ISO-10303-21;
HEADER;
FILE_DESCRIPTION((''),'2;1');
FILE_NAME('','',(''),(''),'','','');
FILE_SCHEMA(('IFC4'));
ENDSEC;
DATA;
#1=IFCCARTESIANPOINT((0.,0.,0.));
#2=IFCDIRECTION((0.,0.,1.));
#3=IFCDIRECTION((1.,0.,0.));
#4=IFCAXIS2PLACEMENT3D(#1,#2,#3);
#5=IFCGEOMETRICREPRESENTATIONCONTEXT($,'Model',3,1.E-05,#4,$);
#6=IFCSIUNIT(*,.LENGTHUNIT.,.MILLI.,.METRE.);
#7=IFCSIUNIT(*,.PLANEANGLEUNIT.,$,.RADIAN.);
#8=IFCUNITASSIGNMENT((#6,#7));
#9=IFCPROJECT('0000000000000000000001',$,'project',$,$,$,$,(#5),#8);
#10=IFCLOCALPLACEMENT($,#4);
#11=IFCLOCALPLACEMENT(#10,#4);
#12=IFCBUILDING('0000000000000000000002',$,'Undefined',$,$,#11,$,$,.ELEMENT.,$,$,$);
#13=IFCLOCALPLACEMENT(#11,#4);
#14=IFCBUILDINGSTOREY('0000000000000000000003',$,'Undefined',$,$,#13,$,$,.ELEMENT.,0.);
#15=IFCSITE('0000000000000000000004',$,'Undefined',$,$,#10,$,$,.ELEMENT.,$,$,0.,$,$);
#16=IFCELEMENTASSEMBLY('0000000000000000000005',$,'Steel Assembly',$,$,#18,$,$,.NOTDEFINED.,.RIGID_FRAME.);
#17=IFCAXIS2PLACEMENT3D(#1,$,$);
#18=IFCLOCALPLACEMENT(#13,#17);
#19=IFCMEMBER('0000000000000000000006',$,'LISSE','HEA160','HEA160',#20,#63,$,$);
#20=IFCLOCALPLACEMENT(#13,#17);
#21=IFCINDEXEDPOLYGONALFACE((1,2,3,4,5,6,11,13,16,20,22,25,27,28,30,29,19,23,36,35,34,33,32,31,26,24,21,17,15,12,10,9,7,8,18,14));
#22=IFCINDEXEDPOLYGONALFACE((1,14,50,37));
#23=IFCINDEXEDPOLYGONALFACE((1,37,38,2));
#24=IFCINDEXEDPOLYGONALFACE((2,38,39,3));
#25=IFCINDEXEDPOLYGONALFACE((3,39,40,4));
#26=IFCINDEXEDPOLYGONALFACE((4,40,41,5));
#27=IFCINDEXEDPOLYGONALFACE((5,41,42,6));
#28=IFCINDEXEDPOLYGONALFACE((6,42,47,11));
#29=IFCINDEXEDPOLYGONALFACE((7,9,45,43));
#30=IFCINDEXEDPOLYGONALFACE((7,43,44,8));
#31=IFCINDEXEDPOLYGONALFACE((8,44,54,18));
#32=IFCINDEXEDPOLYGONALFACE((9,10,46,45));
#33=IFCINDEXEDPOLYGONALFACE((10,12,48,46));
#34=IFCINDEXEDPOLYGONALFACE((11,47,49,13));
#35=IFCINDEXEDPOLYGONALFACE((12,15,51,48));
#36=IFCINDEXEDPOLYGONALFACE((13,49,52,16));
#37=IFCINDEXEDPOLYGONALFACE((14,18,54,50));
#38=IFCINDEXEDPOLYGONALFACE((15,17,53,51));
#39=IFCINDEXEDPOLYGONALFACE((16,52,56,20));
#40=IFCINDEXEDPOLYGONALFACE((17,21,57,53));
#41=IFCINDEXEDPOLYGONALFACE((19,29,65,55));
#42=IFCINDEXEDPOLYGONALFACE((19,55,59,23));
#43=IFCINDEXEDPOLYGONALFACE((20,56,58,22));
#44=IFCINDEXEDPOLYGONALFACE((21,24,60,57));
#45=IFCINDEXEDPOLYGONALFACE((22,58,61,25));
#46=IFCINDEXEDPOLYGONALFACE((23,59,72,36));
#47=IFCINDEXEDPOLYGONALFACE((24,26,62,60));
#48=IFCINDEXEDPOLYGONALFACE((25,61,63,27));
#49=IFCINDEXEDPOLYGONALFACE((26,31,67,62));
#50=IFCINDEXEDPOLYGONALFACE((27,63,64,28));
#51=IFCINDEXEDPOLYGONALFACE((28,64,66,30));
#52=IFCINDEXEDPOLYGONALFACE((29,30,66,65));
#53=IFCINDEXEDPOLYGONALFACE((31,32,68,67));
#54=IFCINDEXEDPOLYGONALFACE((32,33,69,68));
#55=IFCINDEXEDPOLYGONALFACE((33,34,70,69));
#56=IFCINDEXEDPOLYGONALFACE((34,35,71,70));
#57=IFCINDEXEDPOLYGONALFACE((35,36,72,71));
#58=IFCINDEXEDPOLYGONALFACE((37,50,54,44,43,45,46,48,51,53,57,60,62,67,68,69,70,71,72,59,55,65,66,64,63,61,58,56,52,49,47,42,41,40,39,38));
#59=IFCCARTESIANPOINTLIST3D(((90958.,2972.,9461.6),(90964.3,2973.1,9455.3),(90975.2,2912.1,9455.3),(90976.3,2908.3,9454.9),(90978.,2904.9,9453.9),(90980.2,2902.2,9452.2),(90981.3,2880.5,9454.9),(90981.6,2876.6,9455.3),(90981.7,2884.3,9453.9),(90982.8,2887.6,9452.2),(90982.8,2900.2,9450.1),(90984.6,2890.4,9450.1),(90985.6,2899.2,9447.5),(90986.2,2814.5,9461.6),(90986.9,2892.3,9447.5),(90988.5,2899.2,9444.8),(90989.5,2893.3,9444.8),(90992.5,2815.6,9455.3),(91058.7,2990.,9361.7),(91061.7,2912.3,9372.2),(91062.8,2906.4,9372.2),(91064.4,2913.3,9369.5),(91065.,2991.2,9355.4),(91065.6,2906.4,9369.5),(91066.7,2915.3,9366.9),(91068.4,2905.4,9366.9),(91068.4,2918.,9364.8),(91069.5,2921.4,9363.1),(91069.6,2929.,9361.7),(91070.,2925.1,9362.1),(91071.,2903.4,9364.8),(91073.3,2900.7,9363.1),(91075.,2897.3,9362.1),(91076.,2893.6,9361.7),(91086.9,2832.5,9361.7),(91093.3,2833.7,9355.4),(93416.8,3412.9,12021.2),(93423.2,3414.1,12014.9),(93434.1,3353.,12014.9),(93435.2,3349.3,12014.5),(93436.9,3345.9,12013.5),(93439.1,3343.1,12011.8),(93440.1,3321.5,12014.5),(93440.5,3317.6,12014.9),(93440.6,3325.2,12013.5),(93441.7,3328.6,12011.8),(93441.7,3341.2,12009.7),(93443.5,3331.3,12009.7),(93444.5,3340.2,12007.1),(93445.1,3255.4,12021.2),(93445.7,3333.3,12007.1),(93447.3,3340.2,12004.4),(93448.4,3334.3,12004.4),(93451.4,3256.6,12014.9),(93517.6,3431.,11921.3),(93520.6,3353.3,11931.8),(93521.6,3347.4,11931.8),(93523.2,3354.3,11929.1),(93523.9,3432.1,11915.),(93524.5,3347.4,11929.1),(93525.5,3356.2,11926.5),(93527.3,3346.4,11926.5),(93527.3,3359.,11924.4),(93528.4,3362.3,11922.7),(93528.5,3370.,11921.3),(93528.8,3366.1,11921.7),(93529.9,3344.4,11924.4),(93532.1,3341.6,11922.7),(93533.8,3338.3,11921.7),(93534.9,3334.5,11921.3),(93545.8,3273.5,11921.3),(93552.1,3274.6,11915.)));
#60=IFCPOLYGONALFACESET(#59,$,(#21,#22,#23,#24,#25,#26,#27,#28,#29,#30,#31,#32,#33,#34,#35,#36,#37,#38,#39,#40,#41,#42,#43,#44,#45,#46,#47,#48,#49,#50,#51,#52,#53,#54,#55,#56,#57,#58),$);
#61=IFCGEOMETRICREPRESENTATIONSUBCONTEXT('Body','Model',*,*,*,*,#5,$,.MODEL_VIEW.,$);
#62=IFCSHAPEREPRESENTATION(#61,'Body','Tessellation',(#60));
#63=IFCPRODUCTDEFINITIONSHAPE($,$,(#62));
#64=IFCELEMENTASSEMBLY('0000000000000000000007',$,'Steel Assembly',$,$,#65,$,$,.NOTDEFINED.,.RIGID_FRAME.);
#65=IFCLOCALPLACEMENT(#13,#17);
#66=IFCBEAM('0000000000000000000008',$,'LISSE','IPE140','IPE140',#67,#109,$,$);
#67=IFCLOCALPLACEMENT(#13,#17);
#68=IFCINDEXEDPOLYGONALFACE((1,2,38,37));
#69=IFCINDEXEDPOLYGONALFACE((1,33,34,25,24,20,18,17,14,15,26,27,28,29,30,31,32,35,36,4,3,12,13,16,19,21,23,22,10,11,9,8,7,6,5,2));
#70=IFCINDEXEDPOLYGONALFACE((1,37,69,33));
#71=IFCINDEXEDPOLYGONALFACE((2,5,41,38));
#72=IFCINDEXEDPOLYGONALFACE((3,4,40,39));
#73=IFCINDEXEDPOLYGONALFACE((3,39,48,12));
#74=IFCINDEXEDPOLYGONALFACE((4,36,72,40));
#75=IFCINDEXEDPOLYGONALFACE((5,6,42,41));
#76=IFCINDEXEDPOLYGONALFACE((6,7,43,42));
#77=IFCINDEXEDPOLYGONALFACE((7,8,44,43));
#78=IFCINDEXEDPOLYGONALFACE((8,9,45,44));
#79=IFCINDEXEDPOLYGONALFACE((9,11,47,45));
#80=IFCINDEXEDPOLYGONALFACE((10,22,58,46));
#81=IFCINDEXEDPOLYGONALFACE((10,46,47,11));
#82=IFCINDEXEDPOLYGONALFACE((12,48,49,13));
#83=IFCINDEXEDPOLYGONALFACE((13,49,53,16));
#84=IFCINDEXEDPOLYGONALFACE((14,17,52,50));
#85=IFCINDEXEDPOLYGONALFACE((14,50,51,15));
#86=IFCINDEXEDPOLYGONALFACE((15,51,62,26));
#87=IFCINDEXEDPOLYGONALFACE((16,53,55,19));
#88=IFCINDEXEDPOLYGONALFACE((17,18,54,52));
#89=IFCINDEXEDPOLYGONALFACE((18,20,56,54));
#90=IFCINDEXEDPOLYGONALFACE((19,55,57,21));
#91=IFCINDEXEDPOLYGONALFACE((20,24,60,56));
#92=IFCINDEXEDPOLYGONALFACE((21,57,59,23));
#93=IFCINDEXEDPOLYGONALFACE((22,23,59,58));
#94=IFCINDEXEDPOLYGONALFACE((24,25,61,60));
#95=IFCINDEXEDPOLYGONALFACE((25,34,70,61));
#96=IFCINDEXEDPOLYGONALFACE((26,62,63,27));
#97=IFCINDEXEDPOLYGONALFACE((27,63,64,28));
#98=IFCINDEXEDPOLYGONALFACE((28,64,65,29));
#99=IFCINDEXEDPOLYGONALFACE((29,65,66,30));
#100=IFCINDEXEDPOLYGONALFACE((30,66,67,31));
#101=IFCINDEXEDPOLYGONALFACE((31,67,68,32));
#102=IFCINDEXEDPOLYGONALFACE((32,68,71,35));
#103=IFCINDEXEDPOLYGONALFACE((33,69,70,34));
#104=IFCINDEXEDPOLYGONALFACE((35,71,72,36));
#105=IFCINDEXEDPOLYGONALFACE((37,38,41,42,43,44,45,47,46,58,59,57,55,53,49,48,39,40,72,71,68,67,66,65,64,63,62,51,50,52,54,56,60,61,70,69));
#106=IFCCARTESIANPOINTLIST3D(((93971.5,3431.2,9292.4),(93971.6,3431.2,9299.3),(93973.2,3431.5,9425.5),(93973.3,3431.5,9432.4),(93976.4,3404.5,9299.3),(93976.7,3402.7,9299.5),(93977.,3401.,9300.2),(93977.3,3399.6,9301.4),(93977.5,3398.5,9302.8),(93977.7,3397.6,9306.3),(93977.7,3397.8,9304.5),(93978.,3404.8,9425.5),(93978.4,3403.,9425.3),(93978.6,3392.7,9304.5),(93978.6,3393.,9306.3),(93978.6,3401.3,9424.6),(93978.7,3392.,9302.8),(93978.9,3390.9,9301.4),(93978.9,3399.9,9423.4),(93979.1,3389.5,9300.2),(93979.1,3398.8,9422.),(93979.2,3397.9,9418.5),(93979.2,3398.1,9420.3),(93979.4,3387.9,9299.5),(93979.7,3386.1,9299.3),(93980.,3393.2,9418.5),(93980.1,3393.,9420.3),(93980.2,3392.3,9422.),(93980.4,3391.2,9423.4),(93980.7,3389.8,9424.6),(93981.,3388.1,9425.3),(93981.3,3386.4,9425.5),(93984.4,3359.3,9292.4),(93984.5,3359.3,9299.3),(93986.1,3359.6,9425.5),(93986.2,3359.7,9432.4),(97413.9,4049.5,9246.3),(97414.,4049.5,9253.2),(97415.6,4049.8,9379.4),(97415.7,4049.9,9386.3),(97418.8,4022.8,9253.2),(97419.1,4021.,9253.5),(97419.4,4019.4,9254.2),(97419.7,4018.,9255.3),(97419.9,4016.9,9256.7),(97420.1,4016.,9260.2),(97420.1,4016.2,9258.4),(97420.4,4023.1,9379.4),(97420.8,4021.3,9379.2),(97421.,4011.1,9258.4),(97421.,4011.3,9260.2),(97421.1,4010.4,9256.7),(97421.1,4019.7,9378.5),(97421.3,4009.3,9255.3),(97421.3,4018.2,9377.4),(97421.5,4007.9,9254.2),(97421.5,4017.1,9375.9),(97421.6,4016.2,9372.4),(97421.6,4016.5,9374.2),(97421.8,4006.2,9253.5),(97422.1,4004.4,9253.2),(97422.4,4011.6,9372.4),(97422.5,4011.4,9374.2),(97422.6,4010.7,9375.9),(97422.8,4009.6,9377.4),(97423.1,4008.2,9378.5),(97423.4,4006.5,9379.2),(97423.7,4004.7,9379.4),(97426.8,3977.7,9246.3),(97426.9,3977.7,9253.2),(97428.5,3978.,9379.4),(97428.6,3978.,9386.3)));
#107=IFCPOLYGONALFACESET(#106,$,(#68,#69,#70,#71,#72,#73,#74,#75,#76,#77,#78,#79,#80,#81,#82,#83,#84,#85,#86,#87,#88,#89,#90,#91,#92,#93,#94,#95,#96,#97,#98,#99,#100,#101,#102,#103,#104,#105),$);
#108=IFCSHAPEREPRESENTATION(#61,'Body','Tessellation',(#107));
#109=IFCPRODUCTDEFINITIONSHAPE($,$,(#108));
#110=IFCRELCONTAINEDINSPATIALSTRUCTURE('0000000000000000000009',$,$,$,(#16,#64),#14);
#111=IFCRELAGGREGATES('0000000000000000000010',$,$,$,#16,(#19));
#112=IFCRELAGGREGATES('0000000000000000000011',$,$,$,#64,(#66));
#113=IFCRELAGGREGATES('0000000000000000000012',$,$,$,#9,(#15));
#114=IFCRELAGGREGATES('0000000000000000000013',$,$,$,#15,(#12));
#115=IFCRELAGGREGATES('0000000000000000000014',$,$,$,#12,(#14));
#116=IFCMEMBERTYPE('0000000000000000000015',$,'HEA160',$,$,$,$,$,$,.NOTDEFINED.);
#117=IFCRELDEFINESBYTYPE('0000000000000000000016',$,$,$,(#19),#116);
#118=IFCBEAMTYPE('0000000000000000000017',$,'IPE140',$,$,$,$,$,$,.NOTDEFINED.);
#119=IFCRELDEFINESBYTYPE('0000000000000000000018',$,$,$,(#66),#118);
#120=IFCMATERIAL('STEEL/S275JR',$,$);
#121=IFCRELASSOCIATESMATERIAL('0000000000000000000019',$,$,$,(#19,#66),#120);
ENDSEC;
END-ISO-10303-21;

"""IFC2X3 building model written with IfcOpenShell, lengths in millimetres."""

from ifc_helpers import new_model, si_unit, frame, origin_with_axes, origin_2d_with_axis, place, context, subcontext, project, spatial, i_section, extrude, material, type_object, element, aggregate, save


model = new_model("IFC2X3")

# Units and contexts
model_context = context("Model", 3, precision=1e-05, world=origin_with_axes())
body_context = subcontext(model_context, "Body", "Model", "MODEL_VIEW")
ifc_project = project(units=[si_unit("LENGTHUNIT", "METRE", prefix="MILLI"), si_unit("PLANEANGLEUNIT", "RADIAN")], contexts=[model_context])

# Site, building, storey
site_placement = place(None, origin_with_axes())
site = spatial("IfcSite", under=ifc_project, at=site_placement, Name="Undefined", CompositionType="ELEMENT", RefElevation=0.0)
building_placement = place(site_placement, origin_with_axes())
building = spatial("IfcBuilding", under=site, at=building_placement, Name="Undefined", CompositionType="ELEMENT")
storey_placement = place(building_placement, origin_with_axes())
storey = spatial("IfcBuildingStorey", under=building, at=storey_placement, Name="Undefined", CompositionType="ELEMENT", Elevation=0.0)

# Shared definitions
ifc_material = material(Name="STEEL/S275JR")

# Element assembly, member
member_type_1 = type_object("IfcMemberType", Name="HEA160", PredefinedType="NOTDEFINED")
assembly_1_placement = place(storey_placement, origin_with_axes())
assembly_1 = element("IfcElementAssembly", 1, at=assembly_1_placement, inside=storey, Name="Steel Assembly", AssemblyPlace="NOTDEFINED", PredefinedType="RIGID_FRAME")
member_1_placement = place(assembly_1_placement, frame((93484.5, 3343.8, 11968.1), z_axis=(-0.704417, -0.126328, 0.698454), x_axis=(-0.687486, -0.123291, -0.715655)))
member_1 = element("IfcMember", 2, at=member_1_placement, type_object=member_type_1, material=ifc_material, Name="LISSE", Description="HEA160", ObjectType="HEA160", context=body_context, shape_type="SweptSolid", body=[
    extrude(i_section(OverallWidth=160.0, OverallDepth=152.0, WebThickness=6.0, FlangeThickness=9.0, FilletRadius=15.0, at=origin_2d_with_axis()), frame((3576.6, 0.0, 0.0), z_axis=(-1.0, 0.0, 0.0), x_axis=(0.0, -1.0, 0.0)), (0.0, 0.0, 1.0), 3576.6),
])
aggregate(assembly_1, [member_1])

# Element assembly, beam
assembly_2_placement = place(storey_placement, origin_with_axes())
assembly_2 = element("IfcElementAssembly", 3, at=assembly_2_placement, inside=storey, Name="Steel Assembly", AssemblyPlace="NOTDEFINED", PredefinedType="RIGID_FRAME")
beam_type_1 = type_object("IfcBeamType", Name="IPE140", PredefinedType="NOTDEFINED")
beam_1_placement = place(assembly_2_placement, frame((93978.9, 3395.4, 9362.4), z_axis=(-0.01297, -0.002332, -0.999913), x_axis=(0.984162, 0.176783, -0.013178)))
beam_1 = element("IfcBeam", 4, at=beam_1_placement, type_object=beam_type_1, material=ifc_material, Name="LISSE", Description="IPE140", ObjectType="IPE140", context=body_context, shape_type="SweptSolid", body=[
    extrude(i_section(OverallWidth=73.0, OverallDepth=140.0, WebThickness=4.7, FlangeThickness=6.9, FilletRadius=7.0, at=origin_2d_with_axis()), frame((3497.8, 0.0, 0.0), z_axis=(-1.0, 0.0, 0.0), x_axis=(0.0, -1.0, 0.0)), (0.0, 0.0, 1.0), 3497.8),
])
aggregate(assembly_2, [beam_1])

save(model, "model.ifc")
